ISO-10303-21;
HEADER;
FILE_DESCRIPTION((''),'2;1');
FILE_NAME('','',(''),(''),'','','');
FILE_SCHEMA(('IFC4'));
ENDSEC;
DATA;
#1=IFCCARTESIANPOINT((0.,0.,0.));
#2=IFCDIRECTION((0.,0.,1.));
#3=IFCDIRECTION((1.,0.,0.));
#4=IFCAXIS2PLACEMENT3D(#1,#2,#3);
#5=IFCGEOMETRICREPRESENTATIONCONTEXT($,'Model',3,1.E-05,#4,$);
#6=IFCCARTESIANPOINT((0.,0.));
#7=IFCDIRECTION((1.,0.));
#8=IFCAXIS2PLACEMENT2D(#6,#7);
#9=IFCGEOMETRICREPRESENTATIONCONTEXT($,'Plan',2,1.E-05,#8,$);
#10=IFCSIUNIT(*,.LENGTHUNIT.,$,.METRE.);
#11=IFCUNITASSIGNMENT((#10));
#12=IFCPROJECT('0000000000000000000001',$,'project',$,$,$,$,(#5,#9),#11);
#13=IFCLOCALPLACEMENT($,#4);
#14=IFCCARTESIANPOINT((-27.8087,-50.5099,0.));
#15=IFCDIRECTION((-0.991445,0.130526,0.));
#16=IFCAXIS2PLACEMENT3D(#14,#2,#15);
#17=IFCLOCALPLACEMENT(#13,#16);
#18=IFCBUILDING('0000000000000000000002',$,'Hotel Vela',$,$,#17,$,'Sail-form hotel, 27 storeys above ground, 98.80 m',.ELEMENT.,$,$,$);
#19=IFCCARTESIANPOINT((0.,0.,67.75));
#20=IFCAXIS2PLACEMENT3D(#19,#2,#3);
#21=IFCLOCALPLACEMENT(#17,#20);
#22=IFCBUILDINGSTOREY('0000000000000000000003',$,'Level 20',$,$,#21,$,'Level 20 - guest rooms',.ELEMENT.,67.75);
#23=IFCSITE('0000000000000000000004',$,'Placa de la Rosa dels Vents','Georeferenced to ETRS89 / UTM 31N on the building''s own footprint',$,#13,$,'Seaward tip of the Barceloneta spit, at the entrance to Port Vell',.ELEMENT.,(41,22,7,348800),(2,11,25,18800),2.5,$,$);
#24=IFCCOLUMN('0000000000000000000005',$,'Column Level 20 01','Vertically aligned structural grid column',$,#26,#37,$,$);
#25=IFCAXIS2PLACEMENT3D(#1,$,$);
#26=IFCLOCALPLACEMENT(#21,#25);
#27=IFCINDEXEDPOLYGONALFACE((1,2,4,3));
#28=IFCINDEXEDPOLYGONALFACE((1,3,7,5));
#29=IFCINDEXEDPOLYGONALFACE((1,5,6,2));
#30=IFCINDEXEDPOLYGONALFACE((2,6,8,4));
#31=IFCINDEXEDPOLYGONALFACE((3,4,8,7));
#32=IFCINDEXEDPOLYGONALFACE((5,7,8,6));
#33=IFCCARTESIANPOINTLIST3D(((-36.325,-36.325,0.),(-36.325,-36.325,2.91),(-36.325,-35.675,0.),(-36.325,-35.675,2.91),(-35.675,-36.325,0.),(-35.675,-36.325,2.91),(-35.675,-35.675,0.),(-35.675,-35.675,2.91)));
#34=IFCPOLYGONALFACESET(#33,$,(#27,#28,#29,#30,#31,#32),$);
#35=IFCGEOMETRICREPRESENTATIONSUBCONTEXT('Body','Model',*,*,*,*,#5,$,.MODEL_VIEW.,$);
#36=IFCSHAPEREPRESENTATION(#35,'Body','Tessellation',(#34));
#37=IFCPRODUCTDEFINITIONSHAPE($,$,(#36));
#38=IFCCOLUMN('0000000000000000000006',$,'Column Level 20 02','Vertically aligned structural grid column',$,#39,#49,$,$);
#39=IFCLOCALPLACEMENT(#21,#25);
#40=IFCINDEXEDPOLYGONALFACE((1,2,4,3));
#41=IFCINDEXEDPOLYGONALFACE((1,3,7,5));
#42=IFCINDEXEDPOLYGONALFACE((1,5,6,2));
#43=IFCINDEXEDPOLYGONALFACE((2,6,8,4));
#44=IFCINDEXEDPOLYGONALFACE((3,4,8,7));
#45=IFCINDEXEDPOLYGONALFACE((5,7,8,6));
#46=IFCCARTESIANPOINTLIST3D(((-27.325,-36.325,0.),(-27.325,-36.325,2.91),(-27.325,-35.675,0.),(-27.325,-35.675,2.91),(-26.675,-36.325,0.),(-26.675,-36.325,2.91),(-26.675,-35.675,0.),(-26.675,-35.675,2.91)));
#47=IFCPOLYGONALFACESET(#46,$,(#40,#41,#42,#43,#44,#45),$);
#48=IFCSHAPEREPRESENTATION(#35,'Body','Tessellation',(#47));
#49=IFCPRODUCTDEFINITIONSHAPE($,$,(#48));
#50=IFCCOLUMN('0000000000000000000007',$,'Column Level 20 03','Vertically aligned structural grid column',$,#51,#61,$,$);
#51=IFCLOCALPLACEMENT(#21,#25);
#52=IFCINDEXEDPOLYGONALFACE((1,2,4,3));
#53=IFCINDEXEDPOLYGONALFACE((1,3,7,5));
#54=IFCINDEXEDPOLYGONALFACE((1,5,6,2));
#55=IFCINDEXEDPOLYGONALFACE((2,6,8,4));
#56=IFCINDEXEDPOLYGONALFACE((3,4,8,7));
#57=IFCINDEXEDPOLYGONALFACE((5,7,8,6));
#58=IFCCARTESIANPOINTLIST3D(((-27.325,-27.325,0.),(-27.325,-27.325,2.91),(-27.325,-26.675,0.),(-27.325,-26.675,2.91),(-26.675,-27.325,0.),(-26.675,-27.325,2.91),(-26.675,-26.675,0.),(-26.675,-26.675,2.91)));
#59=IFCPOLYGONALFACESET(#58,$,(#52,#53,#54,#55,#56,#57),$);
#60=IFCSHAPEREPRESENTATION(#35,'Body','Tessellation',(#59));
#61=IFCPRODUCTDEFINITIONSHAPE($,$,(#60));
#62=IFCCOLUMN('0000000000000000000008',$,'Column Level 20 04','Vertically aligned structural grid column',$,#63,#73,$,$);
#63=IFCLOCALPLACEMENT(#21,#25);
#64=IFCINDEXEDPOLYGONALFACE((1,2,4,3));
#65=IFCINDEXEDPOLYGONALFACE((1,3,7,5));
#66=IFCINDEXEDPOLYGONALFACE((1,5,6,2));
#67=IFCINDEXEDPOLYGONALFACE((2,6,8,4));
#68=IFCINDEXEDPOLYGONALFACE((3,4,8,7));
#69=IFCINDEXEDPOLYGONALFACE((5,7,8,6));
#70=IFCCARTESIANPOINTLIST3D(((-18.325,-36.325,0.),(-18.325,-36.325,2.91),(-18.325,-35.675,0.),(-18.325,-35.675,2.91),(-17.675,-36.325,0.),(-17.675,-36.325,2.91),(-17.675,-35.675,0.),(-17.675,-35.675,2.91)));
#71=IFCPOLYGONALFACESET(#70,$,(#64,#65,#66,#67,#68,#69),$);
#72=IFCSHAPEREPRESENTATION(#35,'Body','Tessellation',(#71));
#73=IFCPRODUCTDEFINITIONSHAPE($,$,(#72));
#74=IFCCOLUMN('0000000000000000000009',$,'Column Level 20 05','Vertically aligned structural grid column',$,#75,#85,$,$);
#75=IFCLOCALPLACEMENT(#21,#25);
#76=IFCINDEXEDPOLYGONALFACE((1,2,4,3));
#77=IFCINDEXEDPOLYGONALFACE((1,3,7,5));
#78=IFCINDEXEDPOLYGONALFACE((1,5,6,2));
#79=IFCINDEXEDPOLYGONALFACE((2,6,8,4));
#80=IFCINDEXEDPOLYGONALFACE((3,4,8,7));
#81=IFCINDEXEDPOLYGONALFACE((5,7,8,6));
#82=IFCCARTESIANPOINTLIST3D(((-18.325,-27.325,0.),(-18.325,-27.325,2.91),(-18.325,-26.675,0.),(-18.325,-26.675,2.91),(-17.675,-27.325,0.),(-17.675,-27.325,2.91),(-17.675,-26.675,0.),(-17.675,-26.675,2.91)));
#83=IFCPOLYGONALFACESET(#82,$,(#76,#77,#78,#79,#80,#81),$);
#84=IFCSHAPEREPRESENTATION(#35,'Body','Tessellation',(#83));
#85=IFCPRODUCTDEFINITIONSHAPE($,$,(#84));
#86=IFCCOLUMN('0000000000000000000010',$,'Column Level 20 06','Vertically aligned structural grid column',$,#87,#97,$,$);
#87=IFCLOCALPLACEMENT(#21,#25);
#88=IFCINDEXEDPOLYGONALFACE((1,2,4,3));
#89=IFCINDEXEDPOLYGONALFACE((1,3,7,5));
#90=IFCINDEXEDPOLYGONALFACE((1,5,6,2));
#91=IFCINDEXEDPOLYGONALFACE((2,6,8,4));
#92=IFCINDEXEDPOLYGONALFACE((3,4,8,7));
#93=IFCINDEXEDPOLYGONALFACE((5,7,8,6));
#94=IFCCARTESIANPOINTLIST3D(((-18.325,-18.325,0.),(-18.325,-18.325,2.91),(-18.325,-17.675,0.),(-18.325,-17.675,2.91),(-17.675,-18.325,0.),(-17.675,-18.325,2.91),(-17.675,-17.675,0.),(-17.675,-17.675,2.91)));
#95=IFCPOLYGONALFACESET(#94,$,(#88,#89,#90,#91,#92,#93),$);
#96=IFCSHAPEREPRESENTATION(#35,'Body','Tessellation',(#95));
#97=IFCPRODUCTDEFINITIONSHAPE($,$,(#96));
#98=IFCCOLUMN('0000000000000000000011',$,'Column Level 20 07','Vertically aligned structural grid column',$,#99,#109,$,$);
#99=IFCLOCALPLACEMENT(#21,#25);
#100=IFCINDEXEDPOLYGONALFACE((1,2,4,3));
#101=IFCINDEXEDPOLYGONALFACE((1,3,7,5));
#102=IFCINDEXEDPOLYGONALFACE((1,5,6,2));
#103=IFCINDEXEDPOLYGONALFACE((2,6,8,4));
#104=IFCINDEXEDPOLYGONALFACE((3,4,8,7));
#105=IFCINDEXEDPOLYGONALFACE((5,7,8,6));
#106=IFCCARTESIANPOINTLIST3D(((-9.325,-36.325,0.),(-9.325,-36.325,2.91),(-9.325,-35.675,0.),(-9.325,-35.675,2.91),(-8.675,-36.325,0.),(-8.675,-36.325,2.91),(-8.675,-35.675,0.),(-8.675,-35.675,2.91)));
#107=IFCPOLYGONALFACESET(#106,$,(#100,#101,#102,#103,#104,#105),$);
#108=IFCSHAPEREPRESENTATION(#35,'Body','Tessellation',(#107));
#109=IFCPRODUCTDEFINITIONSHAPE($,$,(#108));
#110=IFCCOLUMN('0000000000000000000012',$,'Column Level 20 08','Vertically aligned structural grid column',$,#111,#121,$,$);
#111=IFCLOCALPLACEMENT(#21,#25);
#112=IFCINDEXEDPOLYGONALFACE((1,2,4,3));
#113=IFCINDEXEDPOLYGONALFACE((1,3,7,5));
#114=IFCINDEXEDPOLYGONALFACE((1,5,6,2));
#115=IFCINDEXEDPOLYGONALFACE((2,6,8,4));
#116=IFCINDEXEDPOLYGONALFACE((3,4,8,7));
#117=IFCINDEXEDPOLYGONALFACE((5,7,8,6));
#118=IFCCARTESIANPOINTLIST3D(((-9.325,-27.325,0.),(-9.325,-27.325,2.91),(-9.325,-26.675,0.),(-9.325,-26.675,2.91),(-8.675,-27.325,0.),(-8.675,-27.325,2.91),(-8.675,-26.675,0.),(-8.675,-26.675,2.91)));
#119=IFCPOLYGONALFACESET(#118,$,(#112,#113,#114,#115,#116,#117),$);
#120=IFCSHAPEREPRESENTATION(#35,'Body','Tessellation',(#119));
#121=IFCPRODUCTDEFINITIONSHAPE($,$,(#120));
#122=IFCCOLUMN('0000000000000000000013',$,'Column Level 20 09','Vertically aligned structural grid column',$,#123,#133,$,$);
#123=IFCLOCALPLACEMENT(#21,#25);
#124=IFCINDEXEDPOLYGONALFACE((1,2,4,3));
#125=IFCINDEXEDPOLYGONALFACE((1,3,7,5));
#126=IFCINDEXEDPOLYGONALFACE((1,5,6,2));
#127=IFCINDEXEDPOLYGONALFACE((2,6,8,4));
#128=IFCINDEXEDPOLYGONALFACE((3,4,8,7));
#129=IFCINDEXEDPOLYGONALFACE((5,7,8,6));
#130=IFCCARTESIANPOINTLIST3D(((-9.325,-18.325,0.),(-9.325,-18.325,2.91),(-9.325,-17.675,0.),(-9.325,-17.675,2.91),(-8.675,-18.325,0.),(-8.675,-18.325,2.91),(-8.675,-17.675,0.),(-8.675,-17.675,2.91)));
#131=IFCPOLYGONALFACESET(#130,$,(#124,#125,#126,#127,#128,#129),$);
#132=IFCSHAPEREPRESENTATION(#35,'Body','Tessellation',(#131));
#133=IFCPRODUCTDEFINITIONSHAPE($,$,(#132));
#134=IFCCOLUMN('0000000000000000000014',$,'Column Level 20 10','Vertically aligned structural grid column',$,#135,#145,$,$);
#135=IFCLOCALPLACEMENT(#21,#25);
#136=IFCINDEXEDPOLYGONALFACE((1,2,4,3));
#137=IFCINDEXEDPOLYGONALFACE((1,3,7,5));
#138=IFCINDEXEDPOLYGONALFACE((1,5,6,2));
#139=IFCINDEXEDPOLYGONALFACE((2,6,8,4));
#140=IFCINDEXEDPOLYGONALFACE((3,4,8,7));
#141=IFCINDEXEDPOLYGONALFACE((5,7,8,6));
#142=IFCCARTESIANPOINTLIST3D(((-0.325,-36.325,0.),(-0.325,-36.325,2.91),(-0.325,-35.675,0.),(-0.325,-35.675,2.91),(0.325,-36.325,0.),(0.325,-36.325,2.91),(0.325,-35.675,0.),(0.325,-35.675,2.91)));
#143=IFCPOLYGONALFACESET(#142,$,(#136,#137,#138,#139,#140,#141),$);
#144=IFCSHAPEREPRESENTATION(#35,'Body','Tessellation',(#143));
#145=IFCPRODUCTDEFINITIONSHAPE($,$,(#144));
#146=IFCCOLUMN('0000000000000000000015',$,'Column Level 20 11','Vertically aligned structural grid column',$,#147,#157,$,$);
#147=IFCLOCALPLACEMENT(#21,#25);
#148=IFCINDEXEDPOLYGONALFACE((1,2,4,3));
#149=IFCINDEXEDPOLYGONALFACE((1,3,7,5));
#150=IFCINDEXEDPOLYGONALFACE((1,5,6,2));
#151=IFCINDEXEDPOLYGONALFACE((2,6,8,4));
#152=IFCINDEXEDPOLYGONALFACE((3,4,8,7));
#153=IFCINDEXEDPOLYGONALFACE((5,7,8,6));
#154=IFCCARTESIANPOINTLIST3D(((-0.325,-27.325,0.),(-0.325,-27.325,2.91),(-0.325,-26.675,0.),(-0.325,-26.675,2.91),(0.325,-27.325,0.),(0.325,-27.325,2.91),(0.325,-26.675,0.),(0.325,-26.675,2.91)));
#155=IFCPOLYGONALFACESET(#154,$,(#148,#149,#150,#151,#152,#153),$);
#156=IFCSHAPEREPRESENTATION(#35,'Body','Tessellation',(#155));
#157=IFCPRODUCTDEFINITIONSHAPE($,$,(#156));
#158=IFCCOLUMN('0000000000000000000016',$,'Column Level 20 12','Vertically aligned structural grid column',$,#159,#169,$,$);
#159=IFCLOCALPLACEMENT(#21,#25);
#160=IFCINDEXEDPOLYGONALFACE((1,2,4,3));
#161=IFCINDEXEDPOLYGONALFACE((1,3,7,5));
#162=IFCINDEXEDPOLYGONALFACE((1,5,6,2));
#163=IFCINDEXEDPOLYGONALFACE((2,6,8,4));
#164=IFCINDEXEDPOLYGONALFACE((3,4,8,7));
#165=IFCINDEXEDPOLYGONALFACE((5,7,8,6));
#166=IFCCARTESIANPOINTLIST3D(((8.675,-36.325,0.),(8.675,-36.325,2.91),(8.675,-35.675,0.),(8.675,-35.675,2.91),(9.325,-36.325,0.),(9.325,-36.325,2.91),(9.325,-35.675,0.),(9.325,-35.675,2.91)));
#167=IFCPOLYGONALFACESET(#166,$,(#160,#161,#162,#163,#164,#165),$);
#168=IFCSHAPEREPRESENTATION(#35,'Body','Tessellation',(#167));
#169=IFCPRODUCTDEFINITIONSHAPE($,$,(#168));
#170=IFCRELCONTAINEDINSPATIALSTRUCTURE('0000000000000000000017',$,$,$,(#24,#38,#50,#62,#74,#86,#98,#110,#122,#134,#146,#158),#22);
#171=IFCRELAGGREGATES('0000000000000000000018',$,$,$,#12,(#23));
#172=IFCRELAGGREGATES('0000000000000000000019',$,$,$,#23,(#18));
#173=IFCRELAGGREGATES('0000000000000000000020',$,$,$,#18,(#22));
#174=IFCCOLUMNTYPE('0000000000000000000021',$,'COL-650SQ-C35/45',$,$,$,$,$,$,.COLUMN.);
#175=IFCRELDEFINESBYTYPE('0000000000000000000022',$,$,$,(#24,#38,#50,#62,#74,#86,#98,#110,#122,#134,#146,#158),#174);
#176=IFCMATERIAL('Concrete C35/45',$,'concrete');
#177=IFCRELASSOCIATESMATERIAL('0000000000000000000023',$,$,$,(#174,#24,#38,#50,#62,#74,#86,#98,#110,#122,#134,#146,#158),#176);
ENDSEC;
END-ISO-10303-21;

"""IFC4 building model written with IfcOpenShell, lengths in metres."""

from ifc_helpers import new_model, si_unit, frame, origin_with_axes, origin_2d_with_axis, place, context, subcontext, project, spatial, line, indexed_curve, rectangle, outline, extrude, material, material_profile, profile_set, profile_usage, type_object, element, save


model = new_model("IFC4")

# Units and contexts
model_context = context("Model", 3, precision=1e-05, world=origin_with_axes())
plan_context = context("Plan", 2, precision=1e-05, world=origin_2d_with_axis())
body_context = subcontext(model_context, "Body", "Model", "MODEL_VIEW")
ifc_project = project(units=[si_unit("LENGTHUNIT", "METRE")], contexts=[model_context, plan_context])

# Site, building, storey
site_placement = place(None, origin_with_axes())
site = spatial("IfcSite", under=ifc_project, at=site_placement, Name="Placa de la Rosa dels Vents", Description="Georeferenced to ETRS89 / UTM 31N on the building's own footprint", LongName="Seaward tip of the Barceloneta spit, at the entrance to Port Vell", CompositionType="ELEMENT", RefLatitude=(41, 22, 7, 348800), RefLongitude=(2, 11, 25, 18800), RefElevation=2.5)
building_placement = place(site_placement, frame((-27.8087, -50.5099, 0.0), z_axis=(0.0, 0.0, 1.0), x_axis=(-0.991445, 0.130526, 0.0)))
building = spatial("IfcBuilding", under=site, at=building_placement, Name="Hotel Vela", LongName="Sail-form hotel, 27 storeys above ground, 98.80 m", CompositionType="ELEMENT")
storey_placement = place(building_placement, frame((0.0, 0.0, 67.75), z_axis=(0.0, 0.0, 1.0), x_axis=(1.0, 0.0, 0.0)))
storey = spatial("IfcBuildingStorey", under=building, at=storey_placement, Name="Level 20", LongName="Level 20 - guest rooms", CompositionType="ELEMENT", Elevation=67.75)

# Columns
ifc_material = material(Name="Concrete C35/45", Category="concrete")
ifc_material_profile = material_profile(ifc_material, rectangle(XDim=0.65, YDim=0.65))
ifc_profile_set = profile_set([ifc_material_profile], Name="COL-650SQ-C35/45")
ifc_profile_usage_1 = profile_usage(ifc_profile_set)
column_type = type_object("IfcColumnType", Name="COL-650SQ-C35/45", PredefinedType="COLUMN", material=ifc_profile_set)
column_1_placement = place(storey_placement, frame((-36.325, -36.325, 0.0), z_axis=(0.0, 0.0, 1.0), x_axis=(1.0, 0.0, 0.0)))
element("IfcColumn", 1, at=column_1_placement, inside=storey, type_object=column_type, material=ifc_profile_usage_1, Name="Column Level 20 01", Description="Vertically aligned structural grid column", context=body_context, shape_type="SweptSolid", body=[
    extrude(outline(indexed_curve([(0.0, 0.0), (0.65, 0.0), (0.65, 0.65), (0.0, 0.65)], segments=[line(1, 2, 3, 4, 1)])), origin_with_axes(), (0.0, 0.0, 1.0), 2.91),
])
ifc_profile_usage_2 = profile_usage(ifc_profile_set)
column_2_placement = place(storey_placement, frame((-27.325, -36.325, 0.0), z_axis=(0.0, 0.0, 1.0), x_axis=(1.0, 0.0, 0.0)))
element("IfcColumn", 2, at=column_2_placement, inside=storey, type_object=column_type, material=ifc_profile_usage_2, Name="Column Level 20 02", Description="Vertically aligned structural grid column", context=body_context, shape_type="SweptSolid", body=[
    extrude(outline(indexed_curve([(0.0, 0.0), (0.65, 0.0), (0.65, 0.65), (0.0, 0.65)], segments=[line(1, 2, 3, 4, 1)])), origin_with_axes(), (0.0, 0.0, 1.0), 2.91),
])
ifc_profile_usage_3 = profile_usage(ifc_profile_set)
column_3_placement = place(storey_placement, frame((-27.325, -27.325, 0.0), z_axis=(0.0, 0.0, 1.0), x_axis=(1.0, 0.0, 0.0)))
element("IfcColumn", 3, at=column_3_placement, inside=storey, type_object=column_type, material=ifc_profile_usage_3, Name="Column Level 20 03", Description="Vertically aligned structural grid column", context=body_context, shape_type="SweptSolid", body=[
    extrude(outline(indexed_curve([(0.0, 0.0), (0.65, 0.0), (0.65, 0.65), (0.0, 0.65)], segments=[line(1, 2, 3, 4, 1)])), origin_with_axes(), (0.0, 0.0, 1.0), 2.91),
])
ifc_profile_usage_4 = profile_usage(ifc_profile_set)
column_4_placement = place(storey_placement, frame((-18.325, -36.325, 0.0), z_axis=(0.0, 0.0, 1.0), x_axis=(1.0, 0.0, 0.0)))
element("IfcColumn", 4, at=column_4_placement, inside=storey, type_object=column_type, material=ifc_profile_usage_4, Name="Column Level 20 04", Description="Vertically aligned structural grid column", context=body_context, shape_type="SweptSolid", body=[
    extrude(outline(indexed_curve([(0.0, 0.0), (0.65, 0.0), (0.65, 0.65), (0.0, 0.65)], segments=[line(1, 2, 3, 4, 1)])), origin_with_axes(), (0.0, 0.0, 1.0), 2.91),
])
ifc_profile_usage_5 = profile_usage(ifc_profile_set)
column_5_placement = place(storey_placement, frame((-18.325, -27.325, 0.0), z_axis=(0.0, 0.0, 1.0), x_axis=(1.0, 0.0, 0.0)))
element("IfcColumn", 5, at=column_5_placement, inside=storey, type_object=column_type, material=ifc_profile_usage_5, Name="Column Level 20 05", Description="Vertically aligned structural grid column", context=body_context, shape_type="SweptSolid", body=[
    extrude(outline(indexed_curve([(0.0, 0.0), (0.65, 0.0), (0.65, 0.65), (0.0, 0.65)], segments=[line(1, 2, 3, 4, 1)])), origin_with_axes(), (0.0, 0.0, 1.0), 2.91),
])
ifc_profile_usage_6 = profile_usage(ifc_profile_set)
column_6_placement = place(storey_placement, frame((-18.325, -18.325, 0.0), z_axis=(0.0, 0.0, 1.0), x_axis=(1.0, 0.0, 0.0)))
element("IfcColumn", 6, at=column_6_placement, inside=storey, type_object=column_type, material=ifc_profile_usage_6, Name="Column Level 20 06", Description="Vertically aligned structural grid column", context=body_context, shape_type="SweptSolid", body=[
    extrude(outline(indexed_curve([(0.0, 0.0), (0.65, 0.0), (0.65, 0.65), (0.0, 0.65)], segments=[line(1, 2, 3, 4, 1)])), origin_with_axes(), (0.0, 0.0, 1.0), 2.91),
])
ifc_profile_usage_7 = profile_usage(ifc_profile_set)
column_7_placement = place(storey_placement, frame((-9.325, -36.325, 0.0), z_axis=(0.0, 0.0, 1.0), x_axis=(1.0, 0.0, 0.0)))
element("IfcColumn", 7, at=column_7_placement, inside=storey, type_object=column_type, material=ifc_profile_usage_7, Name="Column Level 20 07", Description="Vertically aligned structural grid column", context=body_context, shape_type="SweptSolid", body=[
    extrude(outline(indexed_curve([(0.0, 0.0), (0.65, 0.0), (0.65, 0.65), (0.0, 0.65)], segments=[line(1, 2, 3, 4, 1)])), origin_with_axes(), (0.0, 0.0, 1.0), 2.91),
])
ifc_profile_usage_8 = profile_usage(ifc_profile_set)
column_8_placement = place(storey_placement, frame((-9.325, -27.325, 0.0), z_axis=(0.0, 0.0, 1.0), x_axis=(1.0, 0.0, 0.0)))
element("IfcColumn", 8, at=column_8_placement, inside=storey, type_object=column_type, material=ifc_profile_usage_8, Name="Column Level 20 08", Description="Vertically aligned structural grid column", context=body_context, shape_type="SweptSolid", body=[
    extrude(outline(indexed_curve([(0.0, 0.0), (0.65, 0.0), (0.65, 0.65), (0.0, 0.65)], segments=[line(1, 2, 3, 4, 1)])), origin_with_axes(), (0.0, 0.0, 1.0), 2.91),
])
ifc_profile_usage_9 = profile_usage(ifc_profile_set)
column_9_placement = place(storey_placement, frame((-9.325, -18.325, 0.0), z_axis=(0.0, 0.0, 1.0), x_axis=(1.0, 0.0, 0.0)))
element("IfcColumn", 9, at=column_9_placement, inside=storey, type_object=column_type, material=ifc_profile_usage_9, Name="Column Level 20 09", Description="Vertically aligned structural grid column", context=body_context, shape_type="SweptSolid", body=[
    extrude(outline(indexed_curve([(0.0, 0.0), (0.65, 0.0), (0.65, 0.65), (0.0, 0.65)], segments=[line(1, 2, 3, 4, 1)])), origin_with_axes(), (0.0, 0.0, 1.0), 2.91),
])
ifc_profile_usage_10 = profile_usage(ifc_profile_set)
column_10_placement = place(storey_placement, frame((-0.325, -36.325, 0.0), z_axis=(0.0, 0.0, 1.0), x_axis=(1.0, 0.0, 0.0)))
element("IfcColumn", 10, at=column_10_placement, inside=storey, type_object=column_type, material=ifc_profile_usage_10, Name="Column Level 20 10", Description="Vertically aligned structural grid column", context=body_context, shape_type="SweptSolid", body=[
    extrude(outline(indexed_curve([(0.0, 0.0), (0.65, 0.0), (0.65, 0.65), (0.0, 0.65)], segments=[line(1, 2, 3, 4, 1)])), origin_with_axes(), (0.0, 0.0, 1.0), 2.91),
])
ifc_profile_usage_11 = profile_usage(ifc_profile_set)
column_11_placement = place(storey_placement, frame((-0.325, -27.325, 0.0), z_axis=(0.0, 0.0, 1.0), x_axis=(1.0, 0.0, 0.0)))
element("IfcColumn", 11, at=column_11_placement, inside=storey, type_object=column_type, material=ifc_profile_usage_11, Name="Column Level 20 11", Description="Vertically aligned structural grid column", context=body_context, shape_type="SweptSolid", body=[
    extrude(outline(indexed_curve([(0.0, 0.0), (0.65, 0.0), (0.65, 0.65), (0.0, 0.65)], segments=[line(1, 2, 3, 4, 1)])), origin_with_axes(), (0.0, 0.0, 1.0), 2.91),
])
ifc_profile_usage_12 = profile_usage(ifc_profile_set)
column_12_placement = place(storey_placement, frame((8.675, -36.325, 0.0), z_axis=(0.0, 0.0, 1.0), x_axis=(1.0, 0.0, 0.0)))
element("IfcColumn", 12, at=column_12_placement, inside=storey, type_object=column_type, material=ifc_profile_usage_12, Name="Column Level 20 12", Description="Vertically aligned structural grid column", context=body_context, shape_type="SweptSolid", body=[
    extrude(outline(indexed_curve([(0.0, 0.0), (0.65, 0.0), (0.65, 0.65), (0.0, 0.65)], segments=[line(1, 2, 3, 4, 1)])), origin_with_axes(), (0.0, 0.0, 1.0), 2.91),
])

save(model, "model.ifc")
